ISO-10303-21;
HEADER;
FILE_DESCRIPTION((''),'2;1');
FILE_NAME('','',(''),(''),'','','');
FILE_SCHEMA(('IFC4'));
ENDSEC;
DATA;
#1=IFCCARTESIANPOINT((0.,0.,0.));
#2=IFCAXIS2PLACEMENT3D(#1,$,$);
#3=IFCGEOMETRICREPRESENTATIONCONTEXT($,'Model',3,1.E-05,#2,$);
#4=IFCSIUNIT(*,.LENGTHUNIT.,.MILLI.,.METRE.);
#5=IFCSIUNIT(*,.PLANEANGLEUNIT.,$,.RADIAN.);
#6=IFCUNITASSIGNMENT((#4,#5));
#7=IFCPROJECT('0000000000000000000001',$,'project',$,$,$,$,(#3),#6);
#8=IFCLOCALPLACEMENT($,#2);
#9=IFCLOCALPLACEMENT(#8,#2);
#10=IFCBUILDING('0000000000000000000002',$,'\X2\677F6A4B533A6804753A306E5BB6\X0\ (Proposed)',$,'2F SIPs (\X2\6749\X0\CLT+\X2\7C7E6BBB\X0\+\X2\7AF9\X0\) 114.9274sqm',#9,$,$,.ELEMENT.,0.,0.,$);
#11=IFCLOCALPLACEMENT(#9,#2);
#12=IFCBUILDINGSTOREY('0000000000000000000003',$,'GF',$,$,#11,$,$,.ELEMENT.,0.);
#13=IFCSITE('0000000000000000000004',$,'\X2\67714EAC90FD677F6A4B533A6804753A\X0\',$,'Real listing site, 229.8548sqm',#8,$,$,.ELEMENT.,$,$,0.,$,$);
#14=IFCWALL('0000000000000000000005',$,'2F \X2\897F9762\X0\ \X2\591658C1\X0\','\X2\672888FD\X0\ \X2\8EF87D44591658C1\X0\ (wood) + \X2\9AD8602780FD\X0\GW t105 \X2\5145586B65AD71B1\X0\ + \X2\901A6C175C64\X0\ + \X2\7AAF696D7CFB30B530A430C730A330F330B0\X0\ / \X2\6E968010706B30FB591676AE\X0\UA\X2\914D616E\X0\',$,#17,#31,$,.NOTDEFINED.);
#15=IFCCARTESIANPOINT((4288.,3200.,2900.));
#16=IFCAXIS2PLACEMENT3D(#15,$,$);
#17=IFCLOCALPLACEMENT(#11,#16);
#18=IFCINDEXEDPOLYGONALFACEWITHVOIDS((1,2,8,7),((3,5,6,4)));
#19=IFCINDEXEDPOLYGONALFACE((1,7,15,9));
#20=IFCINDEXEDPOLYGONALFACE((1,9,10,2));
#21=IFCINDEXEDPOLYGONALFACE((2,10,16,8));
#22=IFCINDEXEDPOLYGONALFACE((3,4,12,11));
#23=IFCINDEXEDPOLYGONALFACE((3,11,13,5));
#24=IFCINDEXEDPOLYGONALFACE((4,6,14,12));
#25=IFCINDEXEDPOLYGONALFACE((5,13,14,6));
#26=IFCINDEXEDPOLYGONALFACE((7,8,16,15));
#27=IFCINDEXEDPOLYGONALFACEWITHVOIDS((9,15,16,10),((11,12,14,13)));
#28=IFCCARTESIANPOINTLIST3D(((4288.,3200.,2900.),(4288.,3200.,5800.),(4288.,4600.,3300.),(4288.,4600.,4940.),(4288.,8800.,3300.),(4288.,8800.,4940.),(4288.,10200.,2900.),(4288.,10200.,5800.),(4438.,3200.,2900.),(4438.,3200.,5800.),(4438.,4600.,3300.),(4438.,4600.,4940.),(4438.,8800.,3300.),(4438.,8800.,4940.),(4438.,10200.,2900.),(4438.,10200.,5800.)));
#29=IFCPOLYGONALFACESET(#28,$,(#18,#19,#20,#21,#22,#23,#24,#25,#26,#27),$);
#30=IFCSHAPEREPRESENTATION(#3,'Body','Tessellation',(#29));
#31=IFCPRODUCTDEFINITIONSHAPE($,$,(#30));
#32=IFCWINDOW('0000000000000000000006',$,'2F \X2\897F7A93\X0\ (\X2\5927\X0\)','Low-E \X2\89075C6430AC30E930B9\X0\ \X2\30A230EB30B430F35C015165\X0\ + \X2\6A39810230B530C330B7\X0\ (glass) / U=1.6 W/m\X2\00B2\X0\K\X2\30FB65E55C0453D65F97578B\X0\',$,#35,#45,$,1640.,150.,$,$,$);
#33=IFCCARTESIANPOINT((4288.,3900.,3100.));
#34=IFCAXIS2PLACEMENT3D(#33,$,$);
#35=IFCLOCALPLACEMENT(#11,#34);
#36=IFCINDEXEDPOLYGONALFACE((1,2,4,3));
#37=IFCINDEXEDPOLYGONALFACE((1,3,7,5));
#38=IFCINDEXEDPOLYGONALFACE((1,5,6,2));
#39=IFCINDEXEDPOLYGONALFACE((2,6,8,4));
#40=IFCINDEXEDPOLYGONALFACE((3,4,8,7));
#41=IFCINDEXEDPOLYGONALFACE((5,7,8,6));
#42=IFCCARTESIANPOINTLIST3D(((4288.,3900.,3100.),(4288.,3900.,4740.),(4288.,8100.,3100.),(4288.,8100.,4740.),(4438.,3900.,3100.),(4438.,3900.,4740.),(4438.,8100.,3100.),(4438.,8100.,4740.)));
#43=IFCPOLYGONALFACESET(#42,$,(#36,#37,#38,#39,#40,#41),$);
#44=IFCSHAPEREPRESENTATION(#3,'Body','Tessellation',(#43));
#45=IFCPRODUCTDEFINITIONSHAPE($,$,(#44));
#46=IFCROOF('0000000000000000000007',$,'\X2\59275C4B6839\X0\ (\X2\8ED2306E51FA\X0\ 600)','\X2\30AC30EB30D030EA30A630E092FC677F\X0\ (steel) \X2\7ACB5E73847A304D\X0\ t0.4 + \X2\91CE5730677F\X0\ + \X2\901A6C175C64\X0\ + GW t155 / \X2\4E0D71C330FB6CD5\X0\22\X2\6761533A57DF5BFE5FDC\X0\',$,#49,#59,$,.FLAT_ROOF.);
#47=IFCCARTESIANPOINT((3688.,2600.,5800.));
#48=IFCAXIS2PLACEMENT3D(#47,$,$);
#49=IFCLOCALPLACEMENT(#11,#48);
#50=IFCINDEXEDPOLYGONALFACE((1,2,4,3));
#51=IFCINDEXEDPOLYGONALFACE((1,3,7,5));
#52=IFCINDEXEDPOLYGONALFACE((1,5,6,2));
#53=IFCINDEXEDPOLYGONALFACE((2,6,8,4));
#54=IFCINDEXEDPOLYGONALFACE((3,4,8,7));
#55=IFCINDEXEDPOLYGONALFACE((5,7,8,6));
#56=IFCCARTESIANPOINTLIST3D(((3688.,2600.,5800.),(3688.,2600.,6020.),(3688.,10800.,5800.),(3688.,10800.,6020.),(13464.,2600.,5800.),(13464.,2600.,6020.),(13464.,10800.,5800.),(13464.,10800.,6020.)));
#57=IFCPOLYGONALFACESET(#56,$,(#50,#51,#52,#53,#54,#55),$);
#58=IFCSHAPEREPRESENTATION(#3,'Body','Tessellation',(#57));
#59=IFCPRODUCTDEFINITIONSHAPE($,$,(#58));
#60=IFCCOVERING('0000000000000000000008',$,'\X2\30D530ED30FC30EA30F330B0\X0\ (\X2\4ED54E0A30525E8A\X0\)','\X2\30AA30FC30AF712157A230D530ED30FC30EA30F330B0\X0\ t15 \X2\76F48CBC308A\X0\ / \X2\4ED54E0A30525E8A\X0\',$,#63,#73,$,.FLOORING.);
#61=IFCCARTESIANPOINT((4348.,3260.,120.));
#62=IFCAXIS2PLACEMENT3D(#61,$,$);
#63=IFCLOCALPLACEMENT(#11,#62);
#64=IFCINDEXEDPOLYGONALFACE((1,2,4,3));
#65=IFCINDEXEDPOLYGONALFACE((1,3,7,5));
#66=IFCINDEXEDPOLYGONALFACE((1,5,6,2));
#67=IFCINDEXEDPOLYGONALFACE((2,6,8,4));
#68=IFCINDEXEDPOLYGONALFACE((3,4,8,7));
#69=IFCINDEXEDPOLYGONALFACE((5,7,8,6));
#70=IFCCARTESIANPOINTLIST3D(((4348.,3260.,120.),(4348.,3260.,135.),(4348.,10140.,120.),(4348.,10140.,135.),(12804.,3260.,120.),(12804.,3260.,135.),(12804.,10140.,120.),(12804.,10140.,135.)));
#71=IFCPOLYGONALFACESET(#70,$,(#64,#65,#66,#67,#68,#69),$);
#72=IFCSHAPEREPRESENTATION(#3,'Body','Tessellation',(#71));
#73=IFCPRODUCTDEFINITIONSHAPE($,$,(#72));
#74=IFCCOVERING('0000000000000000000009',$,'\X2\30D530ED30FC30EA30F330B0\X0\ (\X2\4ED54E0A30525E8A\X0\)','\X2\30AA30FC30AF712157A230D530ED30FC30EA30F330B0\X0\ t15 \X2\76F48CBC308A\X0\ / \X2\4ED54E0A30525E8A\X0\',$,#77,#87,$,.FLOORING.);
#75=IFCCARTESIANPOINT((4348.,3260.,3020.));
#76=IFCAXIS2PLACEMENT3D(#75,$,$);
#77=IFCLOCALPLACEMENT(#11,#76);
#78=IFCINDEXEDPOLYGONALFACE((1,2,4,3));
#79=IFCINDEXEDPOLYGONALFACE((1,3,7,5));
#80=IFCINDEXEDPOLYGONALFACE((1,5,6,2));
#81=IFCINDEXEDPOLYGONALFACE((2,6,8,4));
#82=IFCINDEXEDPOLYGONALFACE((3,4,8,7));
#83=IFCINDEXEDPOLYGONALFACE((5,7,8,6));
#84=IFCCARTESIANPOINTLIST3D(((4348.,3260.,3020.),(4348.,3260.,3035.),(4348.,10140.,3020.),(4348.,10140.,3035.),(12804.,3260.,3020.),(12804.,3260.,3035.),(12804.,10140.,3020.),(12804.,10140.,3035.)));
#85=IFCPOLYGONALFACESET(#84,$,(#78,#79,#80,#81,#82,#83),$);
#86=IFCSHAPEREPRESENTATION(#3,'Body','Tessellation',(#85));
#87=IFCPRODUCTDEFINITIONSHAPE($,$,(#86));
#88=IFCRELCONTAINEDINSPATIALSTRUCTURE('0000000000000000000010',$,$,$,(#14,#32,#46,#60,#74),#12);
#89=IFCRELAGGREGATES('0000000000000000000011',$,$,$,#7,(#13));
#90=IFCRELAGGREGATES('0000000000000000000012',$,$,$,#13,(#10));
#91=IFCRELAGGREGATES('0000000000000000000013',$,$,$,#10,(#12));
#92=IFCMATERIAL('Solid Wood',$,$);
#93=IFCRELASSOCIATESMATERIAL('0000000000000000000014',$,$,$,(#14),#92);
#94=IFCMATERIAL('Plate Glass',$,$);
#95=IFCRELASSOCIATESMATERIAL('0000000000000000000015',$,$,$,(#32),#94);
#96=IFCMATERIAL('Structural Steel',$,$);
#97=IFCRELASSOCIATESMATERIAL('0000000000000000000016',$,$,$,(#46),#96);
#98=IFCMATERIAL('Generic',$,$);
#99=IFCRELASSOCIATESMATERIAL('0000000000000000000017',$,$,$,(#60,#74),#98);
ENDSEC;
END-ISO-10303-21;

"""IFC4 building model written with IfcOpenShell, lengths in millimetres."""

from ifc_helpers import new_model, si_unit, frame, frame_2d, origin, place, context, project, spatial, rectangle, extrude, material, element, fill, save


model = new_model("IFC4")

# Units and contexts
model_context = context("Model", 3, precision=1e-05, world=origin())
ifc_project = project(units=[si_unit("LENGTHUNIT", "METRE", prefix="MILLI"), si_unit("PLANEANGLEUNIT", "RADIAN")], contexts=[model_context])

# Site, building, storey
site_placement = place(None, origin())
site = spatial("IfcSite", under=ifc_project, at=site_placement, Name="東京都板橋区栄町", ObjectType="Real listing site, 229.8548sqm", CompositionType="ELEMENT", RefElevation=0.0)
building_placement = place(site_placement, origin())
building = spatial("IfcBuilding", under=site, at=building_placement, Name="板橋区栄町の家 (Proposed)", ObjectType="2F SIPs (杉CLT+籾殻+竹) 114.9274sqm", CompositionType="ELEMENT", ElevationOfRefHeight=0.0, ElevationOfTerrain=0.0)
storey_placement = place(building_placement, origin())
storey = spatial("IfcBuildingStorey", under=building, at=storey_placement, Name="GF", CompositionType="ELEMENT", Elevation=0.0)

# Shared definitions
ifc_material_1 = material(Name="Solid Wood")

# Shared definitions
ifc_material_2 = material(Name="Plate Glass")

# Wall, opening, window
wall_1_placement = place(storey_placement, frame((4288.0, 3200.0, 2900.0)))
wall_1 = element("IfcWall", 1, at=wall_1_placement, inside=storey, material=ifc_material_1, Name="2F 西面 外壁", Description="木製 軸組外壁 (wood) + 高性能GW t105 充填断熱 + 通気層 + 窯業系サイディング / 準耐火・外皮UA配慮", PredefinedType="NOTDEFINED", context=model_context, shape_type="SweptSolid", body=[
    extrude(rectangle(XDim=150.0, YDim=7000.0, at=frame_2d((75.0, 3500.0))), frame((4288.0, 3200.0, 2900.0)), (0.0, 0.0, 1.0), 2900.0),
])
opening_1_placement = place(storey_placement, frame((4288.0, 3900.0, 3100.0)))
opening_1 = element("IfcOpeningElement", 2, at=opening_1_placement, cuts=wall_1, PredefinedType="NOTDEFINED", context=model_context, shape_type="SweptSolid", body=[
    extrude(rectangle(XDim=150.0, YDim=4200.0, at=frame_2d((75.0, 2100.0))), frame((4288.0, 3900.0, 3100.0)), (0.0, 0.0, 1.0), 1640.0),
])
window_1_placement = place(storey_placement, frame((4288.0, 3900.0, 3100.0)))
window_1 = element("IfcWindow", 3, at=window_1_placement, inside=storey, material=ifc_material_2, Name="2F 西窓 (大)", Description="Low-E 複層ガラス アルゴン封入 + 樹脂サッシ (glass) / U=1.6 W/m²K・日射取得型", OverallHeight=1640.0, OverallWidth=150.0, context=model_context, shape_type="SweptSolid", body=[
    extrude(rectangle(XDim=150.0, YDim=4200.0, at=frame_2d((75.0, 2100.0))), frame((4288.0, 3900.0, 3100.0)), (0.0, 0.0, 1.0), 1640.0),
])
fill(opening_1, window_1)

# Roof
ifc_material_3 = material(Name="Structural Steel")
roof_placement = place(storey_placement, frame((3688.0, 2600.0, 5800.0)))
element("IfcRoof", 4, at=roof_placement, inside=storey, material=ifc_material_3, Name="大屋根 (軒の出 600)", Description="ガルバリウム鋼板 (steel) 立平葺き t0.4 + 野地板 + 通気層 + GW t155 / 不燃・法22条区域対応", PredefinedType="FLAT_ROOF", context=model_context, shape_type="SweptSolid", body=[
    extrude(rectangle(XDim=9776.0, YDim=8200.0, at=frame_2d((4888.0, 4100.0))), frame((3688.0, 2600.0, 5800.0)), (0.0, 0.0, 1.0), 220.0),
])

# Coverings
ifc_material_4 = material(Name="Generic")
covering_1_placement = place(storey_placement, frame((4348.0, 3260.0, 120.0)))
element("IfcCovering", 5, at=covering_1_placement, inside=storey, material=ifc_material_4, Name="フローリング (仕上げ床)", Description="オーク無垢フローリング t15 直貼り / 仕上げ床", PredefinedType="FLOORING", context=model_context, shape_type="SweptSolid", body=[
    extrude(rectangle(XDim=8456.0, YDim=6880.0, at=frame_2d((4228.0, 3440.0))), frame((4348.0, 3260.0, 120.0)), (0.0, 0.0, 1.0), 15.0),
])
covering_2_placement = place(storey_placement, frame((4348.0, 3260.0, 3020.0)))
element("IfcCovering", 6, at=covering_2_placement, inside=storey, material=ifc_material_4, Name="フローリング (仕上げ床)", Description="オーク無垢フローリング t15 直貼り / 仕上げ床", PredefinedType="FLOORING", context=model_context, shape_type="SweptSolid", body=[
    extrude(rectangle(XDim=8456.0, YDim=6880.0, at=frame_2d((4228.0, 3440.0))), frame((4348.0, 3260.0, 3020.0)), (0.0, 0.0, 1.0), 15.0),
])

save(model, "model.ifc")
